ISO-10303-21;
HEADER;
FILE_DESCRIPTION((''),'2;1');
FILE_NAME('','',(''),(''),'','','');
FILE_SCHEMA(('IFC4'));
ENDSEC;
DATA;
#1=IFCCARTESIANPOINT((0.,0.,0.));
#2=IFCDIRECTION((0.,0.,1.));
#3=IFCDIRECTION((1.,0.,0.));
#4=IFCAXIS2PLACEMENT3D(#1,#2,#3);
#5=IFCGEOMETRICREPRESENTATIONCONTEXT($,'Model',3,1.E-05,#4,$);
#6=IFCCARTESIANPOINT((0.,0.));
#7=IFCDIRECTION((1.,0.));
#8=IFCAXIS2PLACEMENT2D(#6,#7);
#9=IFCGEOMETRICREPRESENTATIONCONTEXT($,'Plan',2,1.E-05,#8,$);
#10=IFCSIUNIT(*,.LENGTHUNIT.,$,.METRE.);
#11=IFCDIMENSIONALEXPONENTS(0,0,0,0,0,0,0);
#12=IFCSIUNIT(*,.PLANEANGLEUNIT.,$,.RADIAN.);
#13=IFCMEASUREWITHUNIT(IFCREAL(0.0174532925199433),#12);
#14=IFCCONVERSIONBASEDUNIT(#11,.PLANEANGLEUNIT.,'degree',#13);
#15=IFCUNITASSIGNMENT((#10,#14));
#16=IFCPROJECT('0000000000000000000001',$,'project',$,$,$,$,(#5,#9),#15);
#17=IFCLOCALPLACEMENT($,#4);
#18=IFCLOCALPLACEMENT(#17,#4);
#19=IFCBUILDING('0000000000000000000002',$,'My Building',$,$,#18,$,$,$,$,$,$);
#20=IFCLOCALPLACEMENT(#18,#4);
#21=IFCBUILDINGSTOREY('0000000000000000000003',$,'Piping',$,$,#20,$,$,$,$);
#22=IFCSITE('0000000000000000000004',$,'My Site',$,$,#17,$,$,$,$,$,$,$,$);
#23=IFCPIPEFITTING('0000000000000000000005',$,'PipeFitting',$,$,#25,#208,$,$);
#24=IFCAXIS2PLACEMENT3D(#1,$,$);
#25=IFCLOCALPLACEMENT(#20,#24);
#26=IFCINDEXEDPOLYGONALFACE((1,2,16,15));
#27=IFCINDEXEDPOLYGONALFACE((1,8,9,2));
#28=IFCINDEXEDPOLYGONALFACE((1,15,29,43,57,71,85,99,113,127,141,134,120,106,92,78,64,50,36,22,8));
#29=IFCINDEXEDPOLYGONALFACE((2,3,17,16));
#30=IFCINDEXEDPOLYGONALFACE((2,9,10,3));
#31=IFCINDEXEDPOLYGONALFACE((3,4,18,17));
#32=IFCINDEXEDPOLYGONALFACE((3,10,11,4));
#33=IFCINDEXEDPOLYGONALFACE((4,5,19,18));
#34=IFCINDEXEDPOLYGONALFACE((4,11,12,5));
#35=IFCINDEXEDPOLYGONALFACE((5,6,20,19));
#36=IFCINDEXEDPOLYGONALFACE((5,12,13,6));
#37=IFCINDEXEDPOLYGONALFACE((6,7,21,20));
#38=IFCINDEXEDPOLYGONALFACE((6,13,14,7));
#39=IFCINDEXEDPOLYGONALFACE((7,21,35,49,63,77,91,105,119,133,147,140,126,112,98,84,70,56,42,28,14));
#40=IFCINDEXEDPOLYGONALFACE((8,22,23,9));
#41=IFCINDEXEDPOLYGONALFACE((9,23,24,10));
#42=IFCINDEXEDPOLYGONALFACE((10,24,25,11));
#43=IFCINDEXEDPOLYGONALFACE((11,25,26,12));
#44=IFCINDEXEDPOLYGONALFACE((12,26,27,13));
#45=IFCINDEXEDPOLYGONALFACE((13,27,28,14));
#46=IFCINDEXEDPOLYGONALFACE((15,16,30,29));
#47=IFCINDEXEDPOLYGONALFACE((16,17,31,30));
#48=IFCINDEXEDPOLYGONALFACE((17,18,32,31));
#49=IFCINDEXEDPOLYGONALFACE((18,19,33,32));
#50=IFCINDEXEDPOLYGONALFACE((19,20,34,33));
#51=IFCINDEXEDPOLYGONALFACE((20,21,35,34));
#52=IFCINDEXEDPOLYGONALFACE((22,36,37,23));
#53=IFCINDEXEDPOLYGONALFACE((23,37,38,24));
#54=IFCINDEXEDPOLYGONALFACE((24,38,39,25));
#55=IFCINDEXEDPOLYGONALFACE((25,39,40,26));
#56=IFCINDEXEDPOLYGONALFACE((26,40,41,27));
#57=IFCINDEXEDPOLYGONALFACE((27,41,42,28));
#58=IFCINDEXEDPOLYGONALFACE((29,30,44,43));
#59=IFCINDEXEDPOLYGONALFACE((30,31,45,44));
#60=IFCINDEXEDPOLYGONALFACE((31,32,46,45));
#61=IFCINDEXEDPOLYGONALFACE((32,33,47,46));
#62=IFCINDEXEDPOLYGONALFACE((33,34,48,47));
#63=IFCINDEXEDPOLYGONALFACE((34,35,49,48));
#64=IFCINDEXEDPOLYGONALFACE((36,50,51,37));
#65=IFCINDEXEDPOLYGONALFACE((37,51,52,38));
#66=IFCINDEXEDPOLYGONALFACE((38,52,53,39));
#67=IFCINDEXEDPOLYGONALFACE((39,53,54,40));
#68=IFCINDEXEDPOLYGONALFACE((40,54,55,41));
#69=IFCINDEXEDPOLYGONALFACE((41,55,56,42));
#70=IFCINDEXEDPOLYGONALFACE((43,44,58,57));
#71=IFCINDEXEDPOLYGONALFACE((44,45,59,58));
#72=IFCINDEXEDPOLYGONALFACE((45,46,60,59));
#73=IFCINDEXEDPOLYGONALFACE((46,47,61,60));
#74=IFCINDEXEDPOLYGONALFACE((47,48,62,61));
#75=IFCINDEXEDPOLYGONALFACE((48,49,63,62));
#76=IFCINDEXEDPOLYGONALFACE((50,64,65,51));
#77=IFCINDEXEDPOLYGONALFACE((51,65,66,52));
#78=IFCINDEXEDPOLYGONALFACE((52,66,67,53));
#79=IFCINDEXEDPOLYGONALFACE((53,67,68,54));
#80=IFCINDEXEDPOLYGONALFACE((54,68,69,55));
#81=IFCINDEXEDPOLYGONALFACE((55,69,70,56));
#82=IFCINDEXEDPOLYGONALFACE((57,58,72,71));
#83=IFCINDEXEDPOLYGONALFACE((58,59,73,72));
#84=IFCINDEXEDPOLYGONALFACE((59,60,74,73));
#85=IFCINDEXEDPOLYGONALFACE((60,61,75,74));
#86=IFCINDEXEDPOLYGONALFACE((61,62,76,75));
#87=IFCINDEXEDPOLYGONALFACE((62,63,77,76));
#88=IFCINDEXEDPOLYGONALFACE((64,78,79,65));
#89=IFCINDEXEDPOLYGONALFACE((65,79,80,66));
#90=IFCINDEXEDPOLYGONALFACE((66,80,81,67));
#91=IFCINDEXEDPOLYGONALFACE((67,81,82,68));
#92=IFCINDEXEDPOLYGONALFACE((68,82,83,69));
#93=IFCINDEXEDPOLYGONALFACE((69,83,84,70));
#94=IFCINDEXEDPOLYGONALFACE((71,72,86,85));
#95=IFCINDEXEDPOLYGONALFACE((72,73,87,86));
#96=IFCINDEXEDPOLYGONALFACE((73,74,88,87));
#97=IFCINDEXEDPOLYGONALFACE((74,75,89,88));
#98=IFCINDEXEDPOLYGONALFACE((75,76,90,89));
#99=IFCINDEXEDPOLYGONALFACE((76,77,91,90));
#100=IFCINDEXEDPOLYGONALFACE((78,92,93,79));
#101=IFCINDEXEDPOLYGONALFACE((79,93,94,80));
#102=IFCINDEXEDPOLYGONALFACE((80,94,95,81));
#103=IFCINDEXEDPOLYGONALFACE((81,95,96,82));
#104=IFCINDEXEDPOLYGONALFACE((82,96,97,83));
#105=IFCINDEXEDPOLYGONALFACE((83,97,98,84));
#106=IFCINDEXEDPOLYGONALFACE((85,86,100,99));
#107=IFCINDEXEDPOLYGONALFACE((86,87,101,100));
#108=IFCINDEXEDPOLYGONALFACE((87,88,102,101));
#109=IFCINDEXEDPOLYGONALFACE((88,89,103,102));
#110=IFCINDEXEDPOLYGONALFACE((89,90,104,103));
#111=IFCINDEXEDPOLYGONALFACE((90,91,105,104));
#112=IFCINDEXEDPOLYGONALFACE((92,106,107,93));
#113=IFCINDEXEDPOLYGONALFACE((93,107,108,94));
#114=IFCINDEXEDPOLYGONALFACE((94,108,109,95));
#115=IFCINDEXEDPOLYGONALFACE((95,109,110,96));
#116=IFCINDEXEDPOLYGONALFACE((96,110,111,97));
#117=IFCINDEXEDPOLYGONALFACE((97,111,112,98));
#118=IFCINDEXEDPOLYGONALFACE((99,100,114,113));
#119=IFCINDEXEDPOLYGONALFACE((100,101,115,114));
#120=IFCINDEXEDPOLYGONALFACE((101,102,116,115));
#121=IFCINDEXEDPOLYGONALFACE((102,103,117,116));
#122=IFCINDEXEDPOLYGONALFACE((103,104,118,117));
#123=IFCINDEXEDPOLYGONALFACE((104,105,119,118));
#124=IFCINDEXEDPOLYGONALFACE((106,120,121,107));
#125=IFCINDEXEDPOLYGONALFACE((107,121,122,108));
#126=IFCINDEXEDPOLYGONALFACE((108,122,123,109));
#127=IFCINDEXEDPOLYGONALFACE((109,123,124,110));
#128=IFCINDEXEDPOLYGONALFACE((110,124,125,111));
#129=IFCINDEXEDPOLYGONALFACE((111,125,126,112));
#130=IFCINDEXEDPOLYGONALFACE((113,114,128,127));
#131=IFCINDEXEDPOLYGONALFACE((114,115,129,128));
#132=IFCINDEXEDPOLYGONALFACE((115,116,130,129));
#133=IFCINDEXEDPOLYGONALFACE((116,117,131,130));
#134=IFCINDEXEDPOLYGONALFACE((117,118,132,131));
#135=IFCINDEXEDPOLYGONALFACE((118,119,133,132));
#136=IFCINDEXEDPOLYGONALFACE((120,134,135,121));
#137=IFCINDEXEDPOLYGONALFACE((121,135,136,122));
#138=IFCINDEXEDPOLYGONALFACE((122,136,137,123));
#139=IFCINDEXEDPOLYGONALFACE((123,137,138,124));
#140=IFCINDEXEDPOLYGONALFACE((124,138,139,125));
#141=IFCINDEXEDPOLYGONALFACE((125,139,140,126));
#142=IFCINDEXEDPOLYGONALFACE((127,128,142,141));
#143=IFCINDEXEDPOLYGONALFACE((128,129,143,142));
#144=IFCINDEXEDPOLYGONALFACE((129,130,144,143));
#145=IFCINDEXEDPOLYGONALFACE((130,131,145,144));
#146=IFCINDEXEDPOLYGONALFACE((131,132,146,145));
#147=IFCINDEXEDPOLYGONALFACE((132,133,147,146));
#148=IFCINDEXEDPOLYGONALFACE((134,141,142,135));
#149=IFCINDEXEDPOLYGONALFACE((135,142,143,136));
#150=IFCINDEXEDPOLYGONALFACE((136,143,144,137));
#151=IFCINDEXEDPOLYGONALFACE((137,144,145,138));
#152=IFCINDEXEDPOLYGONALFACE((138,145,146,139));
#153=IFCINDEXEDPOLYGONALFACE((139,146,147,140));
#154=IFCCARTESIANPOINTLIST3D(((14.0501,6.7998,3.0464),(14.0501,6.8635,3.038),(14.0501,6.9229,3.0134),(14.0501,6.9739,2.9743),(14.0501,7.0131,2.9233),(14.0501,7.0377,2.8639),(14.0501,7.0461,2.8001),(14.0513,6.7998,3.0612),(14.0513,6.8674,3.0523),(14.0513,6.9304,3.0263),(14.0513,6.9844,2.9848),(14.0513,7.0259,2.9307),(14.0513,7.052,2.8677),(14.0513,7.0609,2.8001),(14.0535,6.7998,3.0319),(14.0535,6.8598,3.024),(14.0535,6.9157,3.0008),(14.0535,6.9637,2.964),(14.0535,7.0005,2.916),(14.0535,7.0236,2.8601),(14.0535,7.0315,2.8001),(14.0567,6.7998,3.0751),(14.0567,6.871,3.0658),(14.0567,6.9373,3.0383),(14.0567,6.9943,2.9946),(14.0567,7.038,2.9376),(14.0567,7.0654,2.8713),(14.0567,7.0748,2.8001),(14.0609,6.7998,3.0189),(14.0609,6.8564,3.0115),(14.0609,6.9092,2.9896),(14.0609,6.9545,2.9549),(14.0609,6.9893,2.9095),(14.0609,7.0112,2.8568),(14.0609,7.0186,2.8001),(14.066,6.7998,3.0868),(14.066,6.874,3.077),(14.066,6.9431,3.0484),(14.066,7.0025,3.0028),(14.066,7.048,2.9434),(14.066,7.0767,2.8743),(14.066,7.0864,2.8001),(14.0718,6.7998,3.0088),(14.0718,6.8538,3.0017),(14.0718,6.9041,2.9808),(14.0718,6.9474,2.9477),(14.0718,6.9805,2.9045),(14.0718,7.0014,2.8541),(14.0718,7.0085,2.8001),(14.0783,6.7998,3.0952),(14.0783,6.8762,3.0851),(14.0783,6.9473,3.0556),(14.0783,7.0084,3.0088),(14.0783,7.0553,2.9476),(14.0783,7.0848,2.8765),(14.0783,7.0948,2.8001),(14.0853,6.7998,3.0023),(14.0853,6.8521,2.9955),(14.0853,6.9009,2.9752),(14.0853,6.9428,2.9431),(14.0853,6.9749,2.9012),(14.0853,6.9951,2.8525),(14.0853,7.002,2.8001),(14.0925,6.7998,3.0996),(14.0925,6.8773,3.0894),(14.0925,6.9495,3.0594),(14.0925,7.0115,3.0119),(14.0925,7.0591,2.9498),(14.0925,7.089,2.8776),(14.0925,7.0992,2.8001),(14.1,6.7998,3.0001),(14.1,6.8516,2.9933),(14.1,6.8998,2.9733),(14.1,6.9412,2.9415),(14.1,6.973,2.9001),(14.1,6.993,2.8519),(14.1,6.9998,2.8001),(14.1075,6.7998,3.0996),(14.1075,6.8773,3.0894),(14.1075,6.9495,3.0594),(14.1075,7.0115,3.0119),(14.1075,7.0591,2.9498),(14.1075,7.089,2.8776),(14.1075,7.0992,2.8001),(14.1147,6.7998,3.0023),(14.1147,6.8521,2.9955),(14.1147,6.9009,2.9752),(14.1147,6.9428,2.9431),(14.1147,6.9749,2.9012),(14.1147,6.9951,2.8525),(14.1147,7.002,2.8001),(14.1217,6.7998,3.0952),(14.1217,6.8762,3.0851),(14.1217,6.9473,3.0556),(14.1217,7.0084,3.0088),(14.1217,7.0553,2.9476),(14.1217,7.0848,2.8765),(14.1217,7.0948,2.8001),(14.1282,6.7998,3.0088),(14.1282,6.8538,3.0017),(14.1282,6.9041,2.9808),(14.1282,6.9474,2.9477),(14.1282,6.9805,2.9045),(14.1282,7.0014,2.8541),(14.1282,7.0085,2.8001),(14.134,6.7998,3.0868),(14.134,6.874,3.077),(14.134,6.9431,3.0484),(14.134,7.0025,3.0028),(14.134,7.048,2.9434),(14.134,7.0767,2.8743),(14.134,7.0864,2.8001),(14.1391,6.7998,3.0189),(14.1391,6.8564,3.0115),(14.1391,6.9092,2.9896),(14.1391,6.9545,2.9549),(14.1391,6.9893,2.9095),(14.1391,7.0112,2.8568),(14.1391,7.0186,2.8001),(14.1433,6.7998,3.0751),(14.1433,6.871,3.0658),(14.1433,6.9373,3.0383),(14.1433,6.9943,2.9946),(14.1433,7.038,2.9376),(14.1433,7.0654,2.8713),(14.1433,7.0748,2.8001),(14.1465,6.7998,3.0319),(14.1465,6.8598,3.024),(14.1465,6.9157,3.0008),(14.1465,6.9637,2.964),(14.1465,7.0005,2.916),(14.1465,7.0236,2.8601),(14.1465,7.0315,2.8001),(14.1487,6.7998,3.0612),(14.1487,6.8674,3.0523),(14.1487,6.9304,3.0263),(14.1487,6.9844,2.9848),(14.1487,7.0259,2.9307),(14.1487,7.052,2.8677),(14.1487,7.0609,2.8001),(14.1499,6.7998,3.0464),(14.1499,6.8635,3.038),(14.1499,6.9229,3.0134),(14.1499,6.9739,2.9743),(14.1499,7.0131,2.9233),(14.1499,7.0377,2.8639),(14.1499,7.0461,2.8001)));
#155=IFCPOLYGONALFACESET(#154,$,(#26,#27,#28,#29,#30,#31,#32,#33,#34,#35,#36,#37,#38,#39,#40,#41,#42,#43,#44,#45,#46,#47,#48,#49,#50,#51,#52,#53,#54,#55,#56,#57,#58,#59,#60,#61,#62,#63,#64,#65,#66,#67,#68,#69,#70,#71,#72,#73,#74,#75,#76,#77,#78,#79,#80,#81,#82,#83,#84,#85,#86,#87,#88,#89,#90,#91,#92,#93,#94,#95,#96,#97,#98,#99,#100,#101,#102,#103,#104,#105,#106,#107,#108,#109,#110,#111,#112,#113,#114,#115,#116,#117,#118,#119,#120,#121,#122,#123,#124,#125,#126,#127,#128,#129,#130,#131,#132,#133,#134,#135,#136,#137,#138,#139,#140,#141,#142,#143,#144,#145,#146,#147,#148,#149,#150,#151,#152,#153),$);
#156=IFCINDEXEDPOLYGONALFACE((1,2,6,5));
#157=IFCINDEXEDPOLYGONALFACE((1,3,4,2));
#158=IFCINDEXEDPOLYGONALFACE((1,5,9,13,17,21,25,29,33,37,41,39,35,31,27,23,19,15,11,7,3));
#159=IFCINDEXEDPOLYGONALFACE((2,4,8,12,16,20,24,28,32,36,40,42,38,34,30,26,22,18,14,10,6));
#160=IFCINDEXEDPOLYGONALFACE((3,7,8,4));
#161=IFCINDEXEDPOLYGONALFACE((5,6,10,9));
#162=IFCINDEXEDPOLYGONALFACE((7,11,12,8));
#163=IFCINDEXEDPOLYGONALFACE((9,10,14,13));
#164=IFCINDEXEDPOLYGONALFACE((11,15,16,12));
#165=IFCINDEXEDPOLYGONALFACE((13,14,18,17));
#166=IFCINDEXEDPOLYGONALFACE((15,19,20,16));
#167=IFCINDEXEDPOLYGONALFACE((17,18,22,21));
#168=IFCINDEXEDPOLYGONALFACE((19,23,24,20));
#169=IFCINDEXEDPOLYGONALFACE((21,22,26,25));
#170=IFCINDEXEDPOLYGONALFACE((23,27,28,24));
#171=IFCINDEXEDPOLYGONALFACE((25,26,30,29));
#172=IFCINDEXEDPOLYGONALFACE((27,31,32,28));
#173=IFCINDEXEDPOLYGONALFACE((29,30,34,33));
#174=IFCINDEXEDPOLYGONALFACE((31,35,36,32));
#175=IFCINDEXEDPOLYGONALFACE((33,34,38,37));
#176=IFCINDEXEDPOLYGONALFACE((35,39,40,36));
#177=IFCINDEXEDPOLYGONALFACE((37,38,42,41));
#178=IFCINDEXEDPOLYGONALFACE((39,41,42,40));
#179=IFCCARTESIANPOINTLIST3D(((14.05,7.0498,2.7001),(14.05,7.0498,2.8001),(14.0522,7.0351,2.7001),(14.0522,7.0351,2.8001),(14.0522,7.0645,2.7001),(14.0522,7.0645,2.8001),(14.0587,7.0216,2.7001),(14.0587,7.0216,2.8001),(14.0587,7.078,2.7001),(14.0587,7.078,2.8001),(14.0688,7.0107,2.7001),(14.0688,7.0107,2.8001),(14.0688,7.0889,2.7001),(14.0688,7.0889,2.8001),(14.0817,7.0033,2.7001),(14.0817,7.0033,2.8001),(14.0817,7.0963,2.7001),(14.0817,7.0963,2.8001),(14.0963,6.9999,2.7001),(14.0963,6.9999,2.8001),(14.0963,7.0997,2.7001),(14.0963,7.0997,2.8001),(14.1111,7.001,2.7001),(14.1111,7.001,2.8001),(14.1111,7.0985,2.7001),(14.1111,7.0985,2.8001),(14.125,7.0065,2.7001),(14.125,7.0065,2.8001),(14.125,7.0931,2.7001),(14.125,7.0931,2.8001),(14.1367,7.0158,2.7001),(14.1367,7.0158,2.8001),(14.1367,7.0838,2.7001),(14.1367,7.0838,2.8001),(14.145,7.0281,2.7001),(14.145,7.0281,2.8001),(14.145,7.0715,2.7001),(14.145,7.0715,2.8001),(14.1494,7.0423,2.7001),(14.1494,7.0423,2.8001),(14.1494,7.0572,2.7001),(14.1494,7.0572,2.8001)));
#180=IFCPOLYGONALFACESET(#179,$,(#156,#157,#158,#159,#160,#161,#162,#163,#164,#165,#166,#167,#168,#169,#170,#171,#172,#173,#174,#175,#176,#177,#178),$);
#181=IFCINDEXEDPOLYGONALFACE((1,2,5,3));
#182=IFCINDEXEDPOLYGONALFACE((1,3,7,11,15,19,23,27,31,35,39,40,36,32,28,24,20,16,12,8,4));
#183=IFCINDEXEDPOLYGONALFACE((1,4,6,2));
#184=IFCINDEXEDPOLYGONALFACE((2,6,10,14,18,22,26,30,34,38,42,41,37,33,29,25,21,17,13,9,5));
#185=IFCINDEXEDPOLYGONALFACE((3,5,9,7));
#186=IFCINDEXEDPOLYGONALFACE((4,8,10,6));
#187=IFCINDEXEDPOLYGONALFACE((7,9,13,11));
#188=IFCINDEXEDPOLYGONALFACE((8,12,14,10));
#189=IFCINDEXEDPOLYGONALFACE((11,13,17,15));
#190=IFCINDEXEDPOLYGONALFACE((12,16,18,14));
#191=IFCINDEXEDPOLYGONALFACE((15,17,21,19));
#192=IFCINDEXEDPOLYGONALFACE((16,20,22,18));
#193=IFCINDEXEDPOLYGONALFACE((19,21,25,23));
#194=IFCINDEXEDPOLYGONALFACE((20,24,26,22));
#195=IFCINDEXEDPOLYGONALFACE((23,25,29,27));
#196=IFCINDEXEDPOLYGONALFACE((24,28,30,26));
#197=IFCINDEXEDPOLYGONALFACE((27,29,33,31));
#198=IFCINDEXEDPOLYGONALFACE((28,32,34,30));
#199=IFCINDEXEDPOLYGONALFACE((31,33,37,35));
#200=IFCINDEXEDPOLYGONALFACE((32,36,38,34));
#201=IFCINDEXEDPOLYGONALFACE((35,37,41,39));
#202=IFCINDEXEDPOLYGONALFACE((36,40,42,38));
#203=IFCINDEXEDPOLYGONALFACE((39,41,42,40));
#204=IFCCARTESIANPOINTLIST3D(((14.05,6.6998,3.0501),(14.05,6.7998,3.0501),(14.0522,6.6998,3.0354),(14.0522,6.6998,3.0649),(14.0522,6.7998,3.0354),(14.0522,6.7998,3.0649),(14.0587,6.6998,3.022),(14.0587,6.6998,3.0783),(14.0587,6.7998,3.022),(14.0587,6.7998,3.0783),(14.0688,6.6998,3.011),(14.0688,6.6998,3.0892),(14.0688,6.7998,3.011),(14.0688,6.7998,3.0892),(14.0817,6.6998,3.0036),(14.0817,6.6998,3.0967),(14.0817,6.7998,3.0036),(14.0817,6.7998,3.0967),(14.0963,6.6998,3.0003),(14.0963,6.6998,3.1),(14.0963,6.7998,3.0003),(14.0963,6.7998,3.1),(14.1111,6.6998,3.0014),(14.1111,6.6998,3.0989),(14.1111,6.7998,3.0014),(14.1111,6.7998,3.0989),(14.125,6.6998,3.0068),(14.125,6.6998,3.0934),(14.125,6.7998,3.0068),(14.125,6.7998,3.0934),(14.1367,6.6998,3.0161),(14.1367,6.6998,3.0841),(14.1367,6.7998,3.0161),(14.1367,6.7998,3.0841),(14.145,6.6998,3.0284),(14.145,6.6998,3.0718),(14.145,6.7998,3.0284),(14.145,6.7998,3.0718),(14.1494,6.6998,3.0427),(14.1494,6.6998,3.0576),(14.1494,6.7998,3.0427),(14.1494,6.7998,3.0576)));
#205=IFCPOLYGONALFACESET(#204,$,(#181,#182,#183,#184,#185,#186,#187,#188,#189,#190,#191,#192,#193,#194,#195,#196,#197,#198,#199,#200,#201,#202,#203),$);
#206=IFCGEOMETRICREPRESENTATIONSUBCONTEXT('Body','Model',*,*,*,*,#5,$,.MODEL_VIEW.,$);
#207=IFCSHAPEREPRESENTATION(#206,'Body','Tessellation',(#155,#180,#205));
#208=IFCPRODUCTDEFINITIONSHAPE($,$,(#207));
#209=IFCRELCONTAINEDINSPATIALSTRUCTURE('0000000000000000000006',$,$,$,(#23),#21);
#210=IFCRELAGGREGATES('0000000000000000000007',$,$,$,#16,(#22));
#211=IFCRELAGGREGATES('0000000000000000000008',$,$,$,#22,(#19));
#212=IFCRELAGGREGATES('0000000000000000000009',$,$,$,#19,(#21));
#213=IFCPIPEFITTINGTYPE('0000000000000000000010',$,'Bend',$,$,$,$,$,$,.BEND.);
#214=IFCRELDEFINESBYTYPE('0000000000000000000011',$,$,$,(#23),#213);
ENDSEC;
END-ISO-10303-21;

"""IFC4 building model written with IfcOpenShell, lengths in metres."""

from ifc_helpers import new_model, entity, si_unit, converted_unit, frame, origin_with_axes, origin_2d_with_axis, place, context, subcontext, project, spatial, circle, extrude, source, transform, mapped, type_object, type_shapes, element, save


model = new_model("IFC4")

# Units and contexts
model_context = context("Model", 3, precision=1e-05, world=origin_with_axes())
plan_context = context("Plan", 2, precision=1e-05, world=origin_2d_with_axis())
body_context = subcontext(model_context, "Body", "Model", "MODEL_VIEW")
ifc_project = project(units=[si_unit("LENGTHUNIT", "METRE"), converted_unit("PLANEANGLEUNIT", "degree", entity("IfcReal", 0.0174532925199433), si_unit("PLANEANGLEUNIT", "RADIAN"), dimensions=[0, 0, 0, 0, 0, 0, 0])], contexts=[model_context, plan_context])

# Site, building, storey
site_placement = place(None, origin_with_axes())
site = spatial("IfcSite", under=ifc_project, at=site_placement, Name="My Site")
building_placement = place(site_placement, origin_with_axes())
building = spatial("IfcBuilding", under=site, at=building_placement, Name="My Building")
storey_placement = place(building_placement, origin_with_axes())
storey = spatial("IfcBuildingStorey", under=building, at=storey_placement, Name="Piping")

# Pipe fitting
pipe_fitting_type_1 = type_object("IfcPipeFittingType", Name="Bend", PredefinedType="BEND")
shared_shape = source(origin_with_axes(), body_context, "Body", "SolidModel", [
    entity("IfcSweptDiskSolid", entity("IfcIndexedPolyCurve", entity("IfcCartesianPointList3D", [[0.0, 0.0, -0.1], [0.0, -0.0732, -0.2768], [0.0, -0.25, -0.35]]), [entity("IfcArcIndex", [1, 2, 3])]), 0.05),
    extrude(circle(Radius=0.05), origin_with_axes(), (0.0, 0.0, -1.0), 0.1),
    extrude(circle(Radius=0.05), frame((0.0, -0.25, -0.35), z_axis=(0.0, -1.0, 0.0), x_axis=(1.0, 0.0, 0.0)), (0.0, 0.0, 1.0), 0.1),
])
type_shapes(pipe_fitting_type_1, [shared_shape])
for number, where, z_axis, x_axis, name in (
    (1, (14.1, 7.0498, 2.7001), (0.0, 0.0, -1.0), (-1.0, 0.0, 0.0), "PipeFitting"),
):
    element("IfcPipeFitting", number, at=place(storey_placement, frame(where, z_axis=z_axis, x_axis=x_axis)), inside=storey, type_object=pipe_fitting_type_1, Name=name, context=body_context, shape_type="MappedRepresentation", body=[
        mapped(shared_shape, transform((0.0, 0.0, 0.0), x_axis=(1.0, 0.0, 0.0), y_axis=(0.0, 1.0, 0.0), z_axis=(0.0, 0.0, 1.0), scale=1.0)),
    ])

save(model, "model.ifc")
